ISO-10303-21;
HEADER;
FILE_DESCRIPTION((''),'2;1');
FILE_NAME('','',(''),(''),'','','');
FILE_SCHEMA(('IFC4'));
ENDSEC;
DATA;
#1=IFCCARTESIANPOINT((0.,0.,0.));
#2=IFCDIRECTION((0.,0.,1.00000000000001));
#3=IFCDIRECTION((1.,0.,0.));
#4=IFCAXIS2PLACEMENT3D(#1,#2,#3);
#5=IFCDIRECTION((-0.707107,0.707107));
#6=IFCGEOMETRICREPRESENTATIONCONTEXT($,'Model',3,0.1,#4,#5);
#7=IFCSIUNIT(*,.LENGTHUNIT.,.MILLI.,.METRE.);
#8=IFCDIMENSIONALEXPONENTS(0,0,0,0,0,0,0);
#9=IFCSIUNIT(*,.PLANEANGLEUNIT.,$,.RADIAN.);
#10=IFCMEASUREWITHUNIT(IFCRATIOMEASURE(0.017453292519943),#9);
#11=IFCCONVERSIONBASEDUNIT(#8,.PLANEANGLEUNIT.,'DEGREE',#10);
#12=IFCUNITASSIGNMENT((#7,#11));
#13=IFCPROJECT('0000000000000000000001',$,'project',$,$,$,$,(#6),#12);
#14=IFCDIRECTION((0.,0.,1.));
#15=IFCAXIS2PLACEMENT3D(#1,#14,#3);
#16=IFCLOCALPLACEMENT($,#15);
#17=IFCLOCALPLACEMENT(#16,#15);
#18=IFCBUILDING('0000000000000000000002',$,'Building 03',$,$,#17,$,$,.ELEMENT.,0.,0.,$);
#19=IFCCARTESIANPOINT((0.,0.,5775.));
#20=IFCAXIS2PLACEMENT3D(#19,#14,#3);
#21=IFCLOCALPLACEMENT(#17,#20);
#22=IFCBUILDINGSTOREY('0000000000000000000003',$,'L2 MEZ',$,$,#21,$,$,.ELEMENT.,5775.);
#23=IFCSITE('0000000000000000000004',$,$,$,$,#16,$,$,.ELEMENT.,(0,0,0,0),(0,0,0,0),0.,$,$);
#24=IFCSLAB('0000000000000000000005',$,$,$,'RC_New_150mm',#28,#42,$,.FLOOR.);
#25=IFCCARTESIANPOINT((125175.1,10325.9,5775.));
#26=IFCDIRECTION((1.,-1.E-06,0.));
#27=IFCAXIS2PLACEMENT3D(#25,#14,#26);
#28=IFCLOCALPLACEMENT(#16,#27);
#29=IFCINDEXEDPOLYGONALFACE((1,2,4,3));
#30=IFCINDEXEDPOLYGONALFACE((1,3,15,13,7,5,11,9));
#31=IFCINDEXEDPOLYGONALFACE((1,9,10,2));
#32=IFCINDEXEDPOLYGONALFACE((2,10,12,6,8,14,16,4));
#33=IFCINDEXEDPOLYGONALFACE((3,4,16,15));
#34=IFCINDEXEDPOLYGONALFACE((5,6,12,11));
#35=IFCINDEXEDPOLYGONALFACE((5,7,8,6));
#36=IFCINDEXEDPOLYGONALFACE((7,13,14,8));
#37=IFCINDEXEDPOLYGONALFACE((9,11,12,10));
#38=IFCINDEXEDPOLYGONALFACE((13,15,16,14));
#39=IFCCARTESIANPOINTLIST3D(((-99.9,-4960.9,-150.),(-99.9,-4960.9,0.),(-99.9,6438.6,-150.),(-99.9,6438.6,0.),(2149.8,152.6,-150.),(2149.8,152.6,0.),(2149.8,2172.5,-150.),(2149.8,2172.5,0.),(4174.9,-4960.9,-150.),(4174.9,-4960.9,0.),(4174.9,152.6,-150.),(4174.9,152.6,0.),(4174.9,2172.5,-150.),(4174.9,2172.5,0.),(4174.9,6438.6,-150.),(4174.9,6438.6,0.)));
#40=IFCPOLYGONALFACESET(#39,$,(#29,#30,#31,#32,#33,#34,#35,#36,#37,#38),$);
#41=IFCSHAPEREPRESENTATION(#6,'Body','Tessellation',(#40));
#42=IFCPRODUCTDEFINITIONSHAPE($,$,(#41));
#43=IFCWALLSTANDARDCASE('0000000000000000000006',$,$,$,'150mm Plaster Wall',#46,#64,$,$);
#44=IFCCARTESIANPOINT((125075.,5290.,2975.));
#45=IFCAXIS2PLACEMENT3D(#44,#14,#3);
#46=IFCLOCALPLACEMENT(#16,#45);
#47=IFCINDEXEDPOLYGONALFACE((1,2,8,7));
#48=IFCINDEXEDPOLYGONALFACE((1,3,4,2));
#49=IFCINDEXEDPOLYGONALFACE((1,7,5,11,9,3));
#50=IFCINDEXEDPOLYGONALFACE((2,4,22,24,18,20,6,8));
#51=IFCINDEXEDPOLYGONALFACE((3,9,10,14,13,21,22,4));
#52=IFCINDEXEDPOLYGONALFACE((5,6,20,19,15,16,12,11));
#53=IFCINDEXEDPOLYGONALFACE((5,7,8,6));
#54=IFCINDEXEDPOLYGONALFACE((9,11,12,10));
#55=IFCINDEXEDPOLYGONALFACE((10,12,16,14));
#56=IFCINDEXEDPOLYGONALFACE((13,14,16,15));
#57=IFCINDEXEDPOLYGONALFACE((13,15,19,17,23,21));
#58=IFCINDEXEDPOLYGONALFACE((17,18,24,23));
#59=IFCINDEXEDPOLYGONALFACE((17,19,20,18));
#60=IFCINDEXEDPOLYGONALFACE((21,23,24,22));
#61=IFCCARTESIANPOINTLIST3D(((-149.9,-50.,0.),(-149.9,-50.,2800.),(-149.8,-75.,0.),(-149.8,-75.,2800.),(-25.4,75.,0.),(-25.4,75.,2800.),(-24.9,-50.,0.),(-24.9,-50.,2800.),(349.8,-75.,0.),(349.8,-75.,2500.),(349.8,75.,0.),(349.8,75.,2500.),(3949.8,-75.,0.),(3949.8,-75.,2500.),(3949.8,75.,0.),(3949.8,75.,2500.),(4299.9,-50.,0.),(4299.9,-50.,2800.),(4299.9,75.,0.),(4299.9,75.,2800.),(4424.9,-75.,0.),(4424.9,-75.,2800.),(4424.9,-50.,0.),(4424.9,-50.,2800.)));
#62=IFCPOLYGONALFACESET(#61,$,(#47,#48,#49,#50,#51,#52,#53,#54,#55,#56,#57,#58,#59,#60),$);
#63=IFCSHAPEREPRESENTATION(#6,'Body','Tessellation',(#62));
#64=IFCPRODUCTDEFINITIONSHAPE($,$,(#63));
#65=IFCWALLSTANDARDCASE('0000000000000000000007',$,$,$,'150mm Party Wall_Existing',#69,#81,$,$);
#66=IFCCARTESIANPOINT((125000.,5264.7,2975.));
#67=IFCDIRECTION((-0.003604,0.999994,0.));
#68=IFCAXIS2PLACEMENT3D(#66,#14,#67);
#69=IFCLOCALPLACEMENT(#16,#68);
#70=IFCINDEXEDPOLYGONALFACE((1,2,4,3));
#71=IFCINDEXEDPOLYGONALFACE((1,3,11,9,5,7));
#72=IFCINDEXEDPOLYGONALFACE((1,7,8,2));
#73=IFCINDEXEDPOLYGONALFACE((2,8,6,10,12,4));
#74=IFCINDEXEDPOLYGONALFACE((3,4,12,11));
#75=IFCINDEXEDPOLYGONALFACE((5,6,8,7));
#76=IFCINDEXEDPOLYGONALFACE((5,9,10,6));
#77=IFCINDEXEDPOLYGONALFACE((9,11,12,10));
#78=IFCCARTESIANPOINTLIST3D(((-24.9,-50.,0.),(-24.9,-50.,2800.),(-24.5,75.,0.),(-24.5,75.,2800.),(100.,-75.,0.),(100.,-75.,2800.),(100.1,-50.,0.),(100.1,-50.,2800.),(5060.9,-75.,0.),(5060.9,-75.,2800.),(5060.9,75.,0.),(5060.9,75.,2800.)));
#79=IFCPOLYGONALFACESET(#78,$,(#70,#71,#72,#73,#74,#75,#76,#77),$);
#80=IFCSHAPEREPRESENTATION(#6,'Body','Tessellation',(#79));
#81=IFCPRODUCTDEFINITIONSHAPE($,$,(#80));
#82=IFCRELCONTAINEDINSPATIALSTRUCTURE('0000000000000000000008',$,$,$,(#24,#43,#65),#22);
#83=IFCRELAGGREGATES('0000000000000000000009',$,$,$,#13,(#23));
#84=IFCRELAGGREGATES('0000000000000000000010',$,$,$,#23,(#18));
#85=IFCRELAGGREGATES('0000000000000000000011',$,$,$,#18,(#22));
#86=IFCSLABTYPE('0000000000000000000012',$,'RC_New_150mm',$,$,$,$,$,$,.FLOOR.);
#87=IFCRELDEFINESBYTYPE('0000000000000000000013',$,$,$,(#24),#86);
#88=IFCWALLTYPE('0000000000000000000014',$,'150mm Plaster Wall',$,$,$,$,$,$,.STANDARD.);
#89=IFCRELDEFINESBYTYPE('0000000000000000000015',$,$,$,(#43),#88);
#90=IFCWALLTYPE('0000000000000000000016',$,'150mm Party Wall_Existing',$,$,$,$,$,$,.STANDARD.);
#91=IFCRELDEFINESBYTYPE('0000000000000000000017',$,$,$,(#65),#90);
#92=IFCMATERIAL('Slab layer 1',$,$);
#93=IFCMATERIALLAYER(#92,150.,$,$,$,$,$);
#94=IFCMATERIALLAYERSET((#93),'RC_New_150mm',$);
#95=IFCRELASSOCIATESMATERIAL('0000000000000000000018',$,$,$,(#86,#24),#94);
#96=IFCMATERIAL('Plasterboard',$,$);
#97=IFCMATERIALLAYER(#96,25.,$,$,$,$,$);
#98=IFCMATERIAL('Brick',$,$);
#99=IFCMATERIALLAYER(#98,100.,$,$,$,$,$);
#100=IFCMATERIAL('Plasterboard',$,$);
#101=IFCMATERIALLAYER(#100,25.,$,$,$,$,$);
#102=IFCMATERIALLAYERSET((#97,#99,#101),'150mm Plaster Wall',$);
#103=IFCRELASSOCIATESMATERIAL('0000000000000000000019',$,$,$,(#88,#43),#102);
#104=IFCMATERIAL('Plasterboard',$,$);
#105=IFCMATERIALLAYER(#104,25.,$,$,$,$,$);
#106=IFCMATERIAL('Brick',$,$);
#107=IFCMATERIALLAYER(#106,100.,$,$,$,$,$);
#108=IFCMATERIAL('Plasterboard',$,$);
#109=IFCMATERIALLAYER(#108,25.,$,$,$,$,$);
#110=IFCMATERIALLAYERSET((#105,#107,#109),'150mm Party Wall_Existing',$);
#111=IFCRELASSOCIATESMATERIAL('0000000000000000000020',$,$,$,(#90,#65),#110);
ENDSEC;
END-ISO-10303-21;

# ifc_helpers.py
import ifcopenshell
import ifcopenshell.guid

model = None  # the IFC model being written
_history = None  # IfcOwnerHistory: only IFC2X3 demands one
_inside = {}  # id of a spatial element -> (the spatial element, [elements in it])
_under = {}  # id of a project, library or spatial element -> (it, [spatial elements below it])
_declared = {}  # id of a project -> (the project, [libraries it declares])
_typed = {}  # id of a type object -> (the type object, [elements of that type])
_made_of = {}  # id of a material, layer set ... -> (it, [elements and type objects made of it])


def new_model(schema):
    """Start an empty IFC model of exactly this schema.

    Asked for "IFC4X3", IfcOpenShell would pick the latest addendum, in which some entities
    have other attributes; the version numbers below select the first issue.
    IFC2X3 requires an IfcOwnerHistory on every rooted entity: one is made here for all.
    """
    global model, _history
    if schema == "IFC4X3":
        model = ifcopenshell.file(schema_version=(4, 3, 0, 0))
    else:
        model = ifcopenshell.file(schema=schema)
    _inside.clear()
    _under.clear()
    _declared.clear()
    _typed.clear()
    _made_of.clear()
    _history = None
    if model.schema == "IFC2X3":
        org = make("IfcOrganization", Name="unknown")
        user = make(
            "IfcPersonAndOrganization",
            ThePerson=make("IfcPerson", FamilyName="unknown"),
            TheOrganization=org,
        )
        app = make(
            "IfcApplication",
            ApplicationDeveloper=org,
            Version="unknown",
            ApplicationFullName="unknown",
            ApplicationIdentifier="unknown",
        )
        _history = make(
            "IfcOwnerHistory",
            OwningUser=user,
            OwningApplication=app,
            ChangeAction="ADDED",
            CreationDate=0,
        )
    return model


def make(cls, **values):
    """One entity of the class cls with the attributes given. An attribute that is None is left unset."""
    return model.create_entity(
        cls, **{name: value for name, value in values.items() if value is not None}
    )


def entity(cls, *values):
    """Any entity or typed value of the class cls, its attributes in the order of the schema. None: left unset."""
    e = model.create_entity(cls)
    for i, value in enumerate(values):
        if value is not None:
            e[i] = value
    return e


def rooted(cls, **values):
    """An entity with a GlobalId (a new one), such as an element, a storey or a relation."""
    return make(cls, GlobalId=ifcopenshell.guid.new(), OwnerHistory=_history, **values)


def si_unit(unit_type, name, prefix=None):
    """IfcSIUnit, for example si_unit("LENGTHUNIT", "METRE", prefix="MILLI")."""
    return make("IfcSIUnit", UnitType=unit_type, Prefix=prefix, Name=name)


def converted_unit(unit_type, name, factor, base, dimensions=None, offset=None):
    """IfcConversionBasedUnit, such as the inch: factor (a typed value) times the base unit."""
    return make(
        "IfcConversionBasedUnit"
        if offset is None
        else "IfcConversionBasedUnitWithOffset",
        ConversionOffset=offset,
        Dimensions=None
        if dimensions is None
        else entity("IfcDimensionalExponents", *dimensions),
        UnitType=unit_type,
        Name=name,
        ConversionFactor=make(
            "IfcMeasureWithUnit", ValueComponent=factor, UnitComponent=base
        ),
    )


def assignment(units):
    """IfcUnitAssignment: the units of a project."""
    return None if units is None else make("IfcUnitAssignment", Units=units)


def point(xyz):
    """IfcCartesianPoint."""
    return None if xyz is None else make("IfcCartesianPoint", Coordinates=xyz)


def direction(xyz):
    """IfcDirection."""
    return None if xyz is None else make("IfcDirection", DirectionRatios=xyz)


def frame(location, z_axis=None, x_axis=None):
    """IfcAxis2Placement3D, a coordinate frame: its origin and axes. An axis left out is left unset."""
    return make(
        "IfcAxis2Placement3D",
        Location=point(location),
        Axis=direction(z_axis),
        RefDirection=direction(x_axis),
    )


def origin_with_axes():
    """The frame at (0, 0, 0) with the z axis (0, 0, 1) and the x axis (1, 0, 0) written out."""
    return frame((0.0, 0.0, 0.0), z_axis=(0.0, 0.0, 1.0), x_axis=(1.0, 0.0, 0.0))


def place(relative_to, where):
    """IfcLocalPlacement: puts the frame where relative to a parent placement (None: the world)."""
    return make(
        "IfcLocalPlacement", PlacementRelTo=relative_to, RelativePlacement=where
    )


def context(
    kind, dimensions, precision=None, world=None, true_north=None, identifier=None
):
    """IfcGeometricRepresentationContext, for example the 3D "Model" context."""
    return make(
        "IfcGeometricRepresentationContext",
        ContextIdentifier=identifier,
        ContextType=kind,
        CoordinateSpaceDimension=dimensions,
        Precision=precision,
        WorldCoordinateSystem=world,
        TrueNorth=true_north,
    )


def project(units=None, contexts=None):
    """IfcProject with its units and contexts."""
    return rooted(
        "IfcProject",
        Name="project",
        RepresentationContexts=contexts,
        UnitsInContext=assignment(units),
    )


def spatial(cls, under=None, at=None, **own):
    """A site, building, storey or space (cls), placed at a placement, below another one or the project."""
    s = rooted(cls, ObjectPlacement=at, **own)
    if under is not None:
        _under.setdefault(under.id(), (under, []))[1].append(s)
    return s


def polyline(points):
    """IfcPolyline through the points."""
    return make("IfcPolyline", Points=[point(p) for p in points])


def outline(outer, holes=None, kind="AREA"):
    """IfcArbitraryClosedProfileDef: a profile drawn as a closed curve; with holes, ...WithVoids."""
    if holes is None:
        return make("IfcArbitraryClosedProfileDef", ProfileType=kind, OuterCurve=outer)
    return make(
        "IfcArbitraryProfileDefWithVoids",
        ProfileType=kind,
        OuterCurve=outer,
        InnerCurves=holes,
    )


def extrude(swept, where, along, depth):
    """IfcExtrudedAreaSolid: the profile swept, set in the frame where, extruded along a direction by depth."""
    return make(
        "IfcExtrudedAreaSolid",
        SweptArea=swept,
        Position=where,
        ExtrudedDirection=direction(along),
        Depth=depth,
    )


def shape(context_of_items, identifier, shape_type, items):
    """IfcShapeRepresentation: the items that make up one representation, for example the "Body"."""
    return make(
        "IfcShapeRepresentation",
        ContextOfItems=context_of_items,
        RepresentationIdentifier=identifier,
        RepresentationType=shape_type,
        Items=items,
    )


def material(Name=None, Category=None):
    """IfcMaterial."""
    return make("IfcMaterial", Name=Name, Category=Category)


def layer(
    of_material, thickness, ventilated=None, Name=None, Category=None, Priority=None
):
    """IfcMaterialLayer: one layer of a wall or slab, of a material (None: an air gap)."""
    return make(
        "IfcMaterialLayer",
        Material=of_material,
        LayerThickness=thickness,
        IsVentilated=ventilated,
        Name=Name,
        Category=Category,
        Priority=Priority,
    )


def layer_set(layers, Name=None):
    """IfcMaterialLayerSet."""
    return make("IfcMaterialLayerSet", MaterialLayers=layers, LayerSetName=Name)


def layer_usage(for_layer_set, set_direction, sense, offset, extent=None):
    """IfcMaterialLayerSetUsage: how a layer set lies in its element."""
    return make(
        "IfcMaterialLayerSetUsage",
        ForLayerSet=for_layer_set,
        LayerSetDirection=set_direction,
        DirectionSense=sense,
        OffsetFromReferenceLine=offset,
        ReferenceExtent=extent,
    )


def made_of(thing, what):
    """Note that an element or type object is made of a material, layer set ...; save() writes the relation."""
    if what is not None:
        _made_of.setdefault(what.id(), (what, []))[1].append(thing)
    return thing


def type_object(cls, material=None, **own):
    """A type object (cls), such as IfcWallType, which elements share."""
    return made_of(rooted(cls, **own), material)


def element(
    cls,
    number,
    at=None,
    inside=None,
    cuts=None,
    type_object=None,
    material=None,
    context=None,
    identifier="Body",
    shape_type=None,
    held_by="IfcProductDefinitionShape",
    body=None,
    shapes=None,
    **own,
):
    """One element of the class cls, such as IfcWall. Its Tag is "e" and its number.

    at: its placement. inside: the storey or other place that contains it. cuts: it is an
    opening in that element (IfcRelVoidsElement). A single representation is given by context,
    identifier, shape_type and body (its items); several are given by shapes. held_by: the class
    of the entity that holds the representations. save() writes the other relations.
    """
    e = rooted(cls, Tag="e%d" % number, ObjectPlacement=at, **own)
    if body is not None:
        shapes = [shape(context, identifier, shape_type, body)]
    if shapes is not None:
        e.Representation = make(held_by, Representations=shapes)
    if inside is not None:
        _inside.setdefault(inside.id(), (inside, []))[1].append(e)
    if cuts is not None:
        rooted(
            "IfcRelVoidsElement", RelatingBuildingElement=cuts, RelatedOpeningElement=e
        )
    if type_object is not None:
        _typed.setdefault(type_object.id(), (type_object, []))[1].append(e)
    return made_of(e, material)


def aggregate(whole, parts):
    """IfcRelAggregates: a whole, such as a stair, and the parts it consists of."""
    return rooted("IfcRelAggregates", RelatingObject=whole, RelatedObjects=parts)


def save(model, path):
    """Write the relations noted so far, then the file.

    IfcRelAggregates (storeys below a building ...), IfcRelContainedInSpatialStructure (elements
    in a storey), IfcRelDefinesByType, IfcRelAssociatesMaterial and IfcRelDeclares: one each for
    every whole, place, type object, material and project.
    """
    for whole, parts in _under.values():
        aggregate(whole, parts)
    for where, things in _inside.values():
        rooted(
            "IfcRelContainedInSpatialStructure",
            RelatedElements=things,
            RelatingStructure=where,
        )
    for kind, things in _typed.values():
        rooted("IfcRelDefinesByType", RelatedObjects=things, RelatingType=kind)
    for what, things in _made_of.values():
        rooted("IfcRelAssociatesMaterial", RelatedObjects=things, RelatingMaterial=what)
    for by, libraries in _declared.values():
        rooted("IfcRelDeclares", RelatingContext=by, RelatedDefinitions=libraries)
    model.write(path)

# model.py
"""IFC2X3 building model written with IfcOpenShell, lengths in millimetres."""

from ifc_helpers import new_model, entity, si_unit, converted_unit, direction, frame, origin_with_axes, place, context, project, spatial, polyline, outline, extrude, material, layer, layer_set, layer_usage, type_object, element, save


model = new_model("IFC2X3")

# Units and contexts
model_context = context("Model", 3, precision=0.1, world=frame((0.0, 0.0, 0.0), z_axis=(0.0, 0.0, 1.00000000000001), x_axis=(1.0, 0.0, 0.0)), true_north=direction((-0.707107, 0.707107)))
ifc_project = project(units=[si_unit("LENGTHUNIT", "METRE", prefix="MILLI"), converted_unit("PLANEANGLEUNIT", "DEGREE", entity("IfcRatioMeasure", 0.017453292519943), si_unit("PLANEANGLEUNIT", "RADIAN"), dimensions=[0, 0, 0, 0, 0, 0, 0])], contexts=[model_context])

# Site, building, storey
site_placement = place(None, origin_with_axes())
site = spatial("IfcSite", under=ifc_project, at=site_placement, CompositionType="ELEMENT", RefLatitude=(0, 0, 0, 0), RefLongitude=(0, 0, 0, 0), RefElevation=0.0)
building_placement = place(site_placement, origin_with_axes())
building = spatial("IfcBuilding", under=site, at=building_placement, Name="Building 03", CompositionType="ELEMENT", ElevationOfRefHeight=0.0, ElevationOfTerrain=0.0)
storey_placement = place(building_placement, frame((0.0, 0.0, 5775.0), z_axis=(0.0, 0.0, 1.0), x_axis=(1.0, 0.0, 0.0)))
storey = spatial("IfcBuildingStorey", under=building, at=storey_placement, Name="L2 MEZ", CompositionType="ELEMENT", Elevation=5775.0)

# Slab
ifc_material_1 = material(Name="Slab layer 1")
ifc_layer_1 = layer(ifc_material_1, 150.0)
ifc_layer_set_1 = layer_set([ifc_layer_1], Name="RC_New_150mm")
ifc_layer_usage_1 = layer_usage(ifc_layer_set_1, "AXIS3", "POSITIVE", 0.0)
slab_type_1 = type_object("IfcSlabType", Name="RC_New_150mm", PredefinedType="FLOOR", material=ifc_layer_set_1)
slab_1_placement = place(site_placement, frame((125175.1, 10325.9, 5775.0), z_axis=(0.0, 0.0, 1.0), x_axis=(1.0, -0.000001, 0.0)))
element("IfcSlab", 1, at=slab_1_placement, inside=storey, type_object=slab_type_1, material=ifc_layer_usage_1, ObjectType="RC_New_150mm", PredefinedType="FLOOR", context=model_context, shape_type="SweptSolid", body=[
    extrude(outline(polyline([(2149.8, 152.6), (4174.9, 152.6), (4174.9, -4960.9), (-99.9, -4960.9), (-99.9, 6438.6), (4174.9, 6438.6), (4174.9, 2172.5), (2149.8, 2172.5), (2149.8, 152.6)])), frame((0.0, 0.0, -150.0), z_axis=(0.0, 0.0, 1.0), x_axis=(1.0, 0.0, 0.0)), (0.0, 0.0, 1.0), 150.0),
])

# Wall, opening
ifc_material_2 = material(Name="Plasterboard")
ifc_layer_2 = layer(ifc_material_2, 25.0)
ifc_material_3 = material(Name="Brick")
ifc_layer_3 = layer(ifc_material_3, 100.0)
ifc_material_4 = material(Name="Plasterboard")
ifc_layer_4 = layer(ifc_material_4, 25.0)
ifc_layer_set_2 = layer_set([ifc_layer_2, ifc_layer_3, ifc_layer_4], Name="150mm Plaster Wall")
ifc_layer_usage_2 = layer_usage(ifc_layer_set_2, "AXIS2", "POSITIVE", -75.0)
wall_type_1 = type_object("IfcWallType", Name="150mm Plaster Wall", PredefinedType="STANDARD", material=ifc_layer_set_2)
wall_1_placement = place(site_placement, frame((125075.0, 5290.0, 2975.0), z_axis=(0.0, 0.0, 1.0), x_axis=(1.0, 0.0, 0.0)))
wall_1 = element("IfcWallStandardCase", 2, at=wall_1_placement, inside=storey, type_object=wall_type_1, material=ifc_layer_usage_2, ObjectType="150mm Plaster Wall", context=model_context, shape_type="SweptSolid", body=[
    extrude(outline(polyline([(4299.9, 75.0), (4299.9, -50.0), (4424.9, -50.0), (4424.9, -75.0), (-149.8, -75.0), (-149.9, -50.0), (-24.9, -50.0), (-25.4, 75.0), (4299.9, 75.0)])), origin_with_axes(), (0.0, 0.0, 1.0), 2800.0),
])
opening_1_placement = place(wall_1_placement, frame((2149.8, 0.0, 0.0), z_axis=(0.0, 0.0, 1.0), x_axis=(1.0, 0.0, 0.0)))
element("IfcOpeningElement", 3, at=opening_1_placement, cuts=wall_1, ObjectType="Opening", context=model_context, shape_type="SweptSolid", body=[
    extrude(outline(polyline([(-1800.0, -1250.0), (1800.0, -1250.0), (1800.0, 1250.0), (-1800.0, 1250.0), (-1800.0, -1250.0)])), frame((0.0, 150.0, 1250.0), z_axis=(0.0, -1.0, 0.0), x_axis=(1.0, 0.0, 0.0)), (0.0, 0.0, 1.0), 300.0),
])

# Wall
ifc_material_5 = material(Name="Plasterboard")
ifc_layer_5 = layer(ifc_material_5, 25.0)
ifc_material_6 = material(Name="Brick")
ifc_layer_6 = layer(ifc_material_6, 100.0)
ifc_material_7 = material(Name="Plasterboard")
ifc_layer_7 = layer(ifc_material_7, 25.0)
ifc_layer_set_3 = layer_set([ifc_layer_5, ifc_layer_6, ifc_layer_7], Name="150mm Party Wall_Existing")
ifc_layer_usage_3 = layer_usage(ifc_layer_set_3, "AXIS2", "POSITIVE", -75.0)
wall_type_2 = type_object("IfcWallType", Name="150mm Party Wall_Existing", PredefinedType="STANDARD", material=ifc_layer_set_3)
wall_2_placement = place(site_placement, frame((125000.0, 5264.7, 2975.0), z_axis=(0.0, 0.0, 1.0), x_axis=(-0.003604, 0.999994, 0.0)))
element("IfcWallStandardCase", 4, at=wall_2_placement, inside=storey, type_object=wall_type_2, material=ifc_layer_usage_3, ObjectType="150mm Party Wall_Existing", context=model_context, shape_type="SweptSolid", body=[
    extrude(outline(polyline([(-24.5, 75.0), (5060.9, 75.0), (5060.9, -75.0), (100.0, -75.0), (100.1, -50.0), (-24.9, -50.0), (-24.5, 75.0)])), origin_with_axes(), (0.0, 0.0, 1.0), 2800.0),
])

save(model, "model.ifc")
